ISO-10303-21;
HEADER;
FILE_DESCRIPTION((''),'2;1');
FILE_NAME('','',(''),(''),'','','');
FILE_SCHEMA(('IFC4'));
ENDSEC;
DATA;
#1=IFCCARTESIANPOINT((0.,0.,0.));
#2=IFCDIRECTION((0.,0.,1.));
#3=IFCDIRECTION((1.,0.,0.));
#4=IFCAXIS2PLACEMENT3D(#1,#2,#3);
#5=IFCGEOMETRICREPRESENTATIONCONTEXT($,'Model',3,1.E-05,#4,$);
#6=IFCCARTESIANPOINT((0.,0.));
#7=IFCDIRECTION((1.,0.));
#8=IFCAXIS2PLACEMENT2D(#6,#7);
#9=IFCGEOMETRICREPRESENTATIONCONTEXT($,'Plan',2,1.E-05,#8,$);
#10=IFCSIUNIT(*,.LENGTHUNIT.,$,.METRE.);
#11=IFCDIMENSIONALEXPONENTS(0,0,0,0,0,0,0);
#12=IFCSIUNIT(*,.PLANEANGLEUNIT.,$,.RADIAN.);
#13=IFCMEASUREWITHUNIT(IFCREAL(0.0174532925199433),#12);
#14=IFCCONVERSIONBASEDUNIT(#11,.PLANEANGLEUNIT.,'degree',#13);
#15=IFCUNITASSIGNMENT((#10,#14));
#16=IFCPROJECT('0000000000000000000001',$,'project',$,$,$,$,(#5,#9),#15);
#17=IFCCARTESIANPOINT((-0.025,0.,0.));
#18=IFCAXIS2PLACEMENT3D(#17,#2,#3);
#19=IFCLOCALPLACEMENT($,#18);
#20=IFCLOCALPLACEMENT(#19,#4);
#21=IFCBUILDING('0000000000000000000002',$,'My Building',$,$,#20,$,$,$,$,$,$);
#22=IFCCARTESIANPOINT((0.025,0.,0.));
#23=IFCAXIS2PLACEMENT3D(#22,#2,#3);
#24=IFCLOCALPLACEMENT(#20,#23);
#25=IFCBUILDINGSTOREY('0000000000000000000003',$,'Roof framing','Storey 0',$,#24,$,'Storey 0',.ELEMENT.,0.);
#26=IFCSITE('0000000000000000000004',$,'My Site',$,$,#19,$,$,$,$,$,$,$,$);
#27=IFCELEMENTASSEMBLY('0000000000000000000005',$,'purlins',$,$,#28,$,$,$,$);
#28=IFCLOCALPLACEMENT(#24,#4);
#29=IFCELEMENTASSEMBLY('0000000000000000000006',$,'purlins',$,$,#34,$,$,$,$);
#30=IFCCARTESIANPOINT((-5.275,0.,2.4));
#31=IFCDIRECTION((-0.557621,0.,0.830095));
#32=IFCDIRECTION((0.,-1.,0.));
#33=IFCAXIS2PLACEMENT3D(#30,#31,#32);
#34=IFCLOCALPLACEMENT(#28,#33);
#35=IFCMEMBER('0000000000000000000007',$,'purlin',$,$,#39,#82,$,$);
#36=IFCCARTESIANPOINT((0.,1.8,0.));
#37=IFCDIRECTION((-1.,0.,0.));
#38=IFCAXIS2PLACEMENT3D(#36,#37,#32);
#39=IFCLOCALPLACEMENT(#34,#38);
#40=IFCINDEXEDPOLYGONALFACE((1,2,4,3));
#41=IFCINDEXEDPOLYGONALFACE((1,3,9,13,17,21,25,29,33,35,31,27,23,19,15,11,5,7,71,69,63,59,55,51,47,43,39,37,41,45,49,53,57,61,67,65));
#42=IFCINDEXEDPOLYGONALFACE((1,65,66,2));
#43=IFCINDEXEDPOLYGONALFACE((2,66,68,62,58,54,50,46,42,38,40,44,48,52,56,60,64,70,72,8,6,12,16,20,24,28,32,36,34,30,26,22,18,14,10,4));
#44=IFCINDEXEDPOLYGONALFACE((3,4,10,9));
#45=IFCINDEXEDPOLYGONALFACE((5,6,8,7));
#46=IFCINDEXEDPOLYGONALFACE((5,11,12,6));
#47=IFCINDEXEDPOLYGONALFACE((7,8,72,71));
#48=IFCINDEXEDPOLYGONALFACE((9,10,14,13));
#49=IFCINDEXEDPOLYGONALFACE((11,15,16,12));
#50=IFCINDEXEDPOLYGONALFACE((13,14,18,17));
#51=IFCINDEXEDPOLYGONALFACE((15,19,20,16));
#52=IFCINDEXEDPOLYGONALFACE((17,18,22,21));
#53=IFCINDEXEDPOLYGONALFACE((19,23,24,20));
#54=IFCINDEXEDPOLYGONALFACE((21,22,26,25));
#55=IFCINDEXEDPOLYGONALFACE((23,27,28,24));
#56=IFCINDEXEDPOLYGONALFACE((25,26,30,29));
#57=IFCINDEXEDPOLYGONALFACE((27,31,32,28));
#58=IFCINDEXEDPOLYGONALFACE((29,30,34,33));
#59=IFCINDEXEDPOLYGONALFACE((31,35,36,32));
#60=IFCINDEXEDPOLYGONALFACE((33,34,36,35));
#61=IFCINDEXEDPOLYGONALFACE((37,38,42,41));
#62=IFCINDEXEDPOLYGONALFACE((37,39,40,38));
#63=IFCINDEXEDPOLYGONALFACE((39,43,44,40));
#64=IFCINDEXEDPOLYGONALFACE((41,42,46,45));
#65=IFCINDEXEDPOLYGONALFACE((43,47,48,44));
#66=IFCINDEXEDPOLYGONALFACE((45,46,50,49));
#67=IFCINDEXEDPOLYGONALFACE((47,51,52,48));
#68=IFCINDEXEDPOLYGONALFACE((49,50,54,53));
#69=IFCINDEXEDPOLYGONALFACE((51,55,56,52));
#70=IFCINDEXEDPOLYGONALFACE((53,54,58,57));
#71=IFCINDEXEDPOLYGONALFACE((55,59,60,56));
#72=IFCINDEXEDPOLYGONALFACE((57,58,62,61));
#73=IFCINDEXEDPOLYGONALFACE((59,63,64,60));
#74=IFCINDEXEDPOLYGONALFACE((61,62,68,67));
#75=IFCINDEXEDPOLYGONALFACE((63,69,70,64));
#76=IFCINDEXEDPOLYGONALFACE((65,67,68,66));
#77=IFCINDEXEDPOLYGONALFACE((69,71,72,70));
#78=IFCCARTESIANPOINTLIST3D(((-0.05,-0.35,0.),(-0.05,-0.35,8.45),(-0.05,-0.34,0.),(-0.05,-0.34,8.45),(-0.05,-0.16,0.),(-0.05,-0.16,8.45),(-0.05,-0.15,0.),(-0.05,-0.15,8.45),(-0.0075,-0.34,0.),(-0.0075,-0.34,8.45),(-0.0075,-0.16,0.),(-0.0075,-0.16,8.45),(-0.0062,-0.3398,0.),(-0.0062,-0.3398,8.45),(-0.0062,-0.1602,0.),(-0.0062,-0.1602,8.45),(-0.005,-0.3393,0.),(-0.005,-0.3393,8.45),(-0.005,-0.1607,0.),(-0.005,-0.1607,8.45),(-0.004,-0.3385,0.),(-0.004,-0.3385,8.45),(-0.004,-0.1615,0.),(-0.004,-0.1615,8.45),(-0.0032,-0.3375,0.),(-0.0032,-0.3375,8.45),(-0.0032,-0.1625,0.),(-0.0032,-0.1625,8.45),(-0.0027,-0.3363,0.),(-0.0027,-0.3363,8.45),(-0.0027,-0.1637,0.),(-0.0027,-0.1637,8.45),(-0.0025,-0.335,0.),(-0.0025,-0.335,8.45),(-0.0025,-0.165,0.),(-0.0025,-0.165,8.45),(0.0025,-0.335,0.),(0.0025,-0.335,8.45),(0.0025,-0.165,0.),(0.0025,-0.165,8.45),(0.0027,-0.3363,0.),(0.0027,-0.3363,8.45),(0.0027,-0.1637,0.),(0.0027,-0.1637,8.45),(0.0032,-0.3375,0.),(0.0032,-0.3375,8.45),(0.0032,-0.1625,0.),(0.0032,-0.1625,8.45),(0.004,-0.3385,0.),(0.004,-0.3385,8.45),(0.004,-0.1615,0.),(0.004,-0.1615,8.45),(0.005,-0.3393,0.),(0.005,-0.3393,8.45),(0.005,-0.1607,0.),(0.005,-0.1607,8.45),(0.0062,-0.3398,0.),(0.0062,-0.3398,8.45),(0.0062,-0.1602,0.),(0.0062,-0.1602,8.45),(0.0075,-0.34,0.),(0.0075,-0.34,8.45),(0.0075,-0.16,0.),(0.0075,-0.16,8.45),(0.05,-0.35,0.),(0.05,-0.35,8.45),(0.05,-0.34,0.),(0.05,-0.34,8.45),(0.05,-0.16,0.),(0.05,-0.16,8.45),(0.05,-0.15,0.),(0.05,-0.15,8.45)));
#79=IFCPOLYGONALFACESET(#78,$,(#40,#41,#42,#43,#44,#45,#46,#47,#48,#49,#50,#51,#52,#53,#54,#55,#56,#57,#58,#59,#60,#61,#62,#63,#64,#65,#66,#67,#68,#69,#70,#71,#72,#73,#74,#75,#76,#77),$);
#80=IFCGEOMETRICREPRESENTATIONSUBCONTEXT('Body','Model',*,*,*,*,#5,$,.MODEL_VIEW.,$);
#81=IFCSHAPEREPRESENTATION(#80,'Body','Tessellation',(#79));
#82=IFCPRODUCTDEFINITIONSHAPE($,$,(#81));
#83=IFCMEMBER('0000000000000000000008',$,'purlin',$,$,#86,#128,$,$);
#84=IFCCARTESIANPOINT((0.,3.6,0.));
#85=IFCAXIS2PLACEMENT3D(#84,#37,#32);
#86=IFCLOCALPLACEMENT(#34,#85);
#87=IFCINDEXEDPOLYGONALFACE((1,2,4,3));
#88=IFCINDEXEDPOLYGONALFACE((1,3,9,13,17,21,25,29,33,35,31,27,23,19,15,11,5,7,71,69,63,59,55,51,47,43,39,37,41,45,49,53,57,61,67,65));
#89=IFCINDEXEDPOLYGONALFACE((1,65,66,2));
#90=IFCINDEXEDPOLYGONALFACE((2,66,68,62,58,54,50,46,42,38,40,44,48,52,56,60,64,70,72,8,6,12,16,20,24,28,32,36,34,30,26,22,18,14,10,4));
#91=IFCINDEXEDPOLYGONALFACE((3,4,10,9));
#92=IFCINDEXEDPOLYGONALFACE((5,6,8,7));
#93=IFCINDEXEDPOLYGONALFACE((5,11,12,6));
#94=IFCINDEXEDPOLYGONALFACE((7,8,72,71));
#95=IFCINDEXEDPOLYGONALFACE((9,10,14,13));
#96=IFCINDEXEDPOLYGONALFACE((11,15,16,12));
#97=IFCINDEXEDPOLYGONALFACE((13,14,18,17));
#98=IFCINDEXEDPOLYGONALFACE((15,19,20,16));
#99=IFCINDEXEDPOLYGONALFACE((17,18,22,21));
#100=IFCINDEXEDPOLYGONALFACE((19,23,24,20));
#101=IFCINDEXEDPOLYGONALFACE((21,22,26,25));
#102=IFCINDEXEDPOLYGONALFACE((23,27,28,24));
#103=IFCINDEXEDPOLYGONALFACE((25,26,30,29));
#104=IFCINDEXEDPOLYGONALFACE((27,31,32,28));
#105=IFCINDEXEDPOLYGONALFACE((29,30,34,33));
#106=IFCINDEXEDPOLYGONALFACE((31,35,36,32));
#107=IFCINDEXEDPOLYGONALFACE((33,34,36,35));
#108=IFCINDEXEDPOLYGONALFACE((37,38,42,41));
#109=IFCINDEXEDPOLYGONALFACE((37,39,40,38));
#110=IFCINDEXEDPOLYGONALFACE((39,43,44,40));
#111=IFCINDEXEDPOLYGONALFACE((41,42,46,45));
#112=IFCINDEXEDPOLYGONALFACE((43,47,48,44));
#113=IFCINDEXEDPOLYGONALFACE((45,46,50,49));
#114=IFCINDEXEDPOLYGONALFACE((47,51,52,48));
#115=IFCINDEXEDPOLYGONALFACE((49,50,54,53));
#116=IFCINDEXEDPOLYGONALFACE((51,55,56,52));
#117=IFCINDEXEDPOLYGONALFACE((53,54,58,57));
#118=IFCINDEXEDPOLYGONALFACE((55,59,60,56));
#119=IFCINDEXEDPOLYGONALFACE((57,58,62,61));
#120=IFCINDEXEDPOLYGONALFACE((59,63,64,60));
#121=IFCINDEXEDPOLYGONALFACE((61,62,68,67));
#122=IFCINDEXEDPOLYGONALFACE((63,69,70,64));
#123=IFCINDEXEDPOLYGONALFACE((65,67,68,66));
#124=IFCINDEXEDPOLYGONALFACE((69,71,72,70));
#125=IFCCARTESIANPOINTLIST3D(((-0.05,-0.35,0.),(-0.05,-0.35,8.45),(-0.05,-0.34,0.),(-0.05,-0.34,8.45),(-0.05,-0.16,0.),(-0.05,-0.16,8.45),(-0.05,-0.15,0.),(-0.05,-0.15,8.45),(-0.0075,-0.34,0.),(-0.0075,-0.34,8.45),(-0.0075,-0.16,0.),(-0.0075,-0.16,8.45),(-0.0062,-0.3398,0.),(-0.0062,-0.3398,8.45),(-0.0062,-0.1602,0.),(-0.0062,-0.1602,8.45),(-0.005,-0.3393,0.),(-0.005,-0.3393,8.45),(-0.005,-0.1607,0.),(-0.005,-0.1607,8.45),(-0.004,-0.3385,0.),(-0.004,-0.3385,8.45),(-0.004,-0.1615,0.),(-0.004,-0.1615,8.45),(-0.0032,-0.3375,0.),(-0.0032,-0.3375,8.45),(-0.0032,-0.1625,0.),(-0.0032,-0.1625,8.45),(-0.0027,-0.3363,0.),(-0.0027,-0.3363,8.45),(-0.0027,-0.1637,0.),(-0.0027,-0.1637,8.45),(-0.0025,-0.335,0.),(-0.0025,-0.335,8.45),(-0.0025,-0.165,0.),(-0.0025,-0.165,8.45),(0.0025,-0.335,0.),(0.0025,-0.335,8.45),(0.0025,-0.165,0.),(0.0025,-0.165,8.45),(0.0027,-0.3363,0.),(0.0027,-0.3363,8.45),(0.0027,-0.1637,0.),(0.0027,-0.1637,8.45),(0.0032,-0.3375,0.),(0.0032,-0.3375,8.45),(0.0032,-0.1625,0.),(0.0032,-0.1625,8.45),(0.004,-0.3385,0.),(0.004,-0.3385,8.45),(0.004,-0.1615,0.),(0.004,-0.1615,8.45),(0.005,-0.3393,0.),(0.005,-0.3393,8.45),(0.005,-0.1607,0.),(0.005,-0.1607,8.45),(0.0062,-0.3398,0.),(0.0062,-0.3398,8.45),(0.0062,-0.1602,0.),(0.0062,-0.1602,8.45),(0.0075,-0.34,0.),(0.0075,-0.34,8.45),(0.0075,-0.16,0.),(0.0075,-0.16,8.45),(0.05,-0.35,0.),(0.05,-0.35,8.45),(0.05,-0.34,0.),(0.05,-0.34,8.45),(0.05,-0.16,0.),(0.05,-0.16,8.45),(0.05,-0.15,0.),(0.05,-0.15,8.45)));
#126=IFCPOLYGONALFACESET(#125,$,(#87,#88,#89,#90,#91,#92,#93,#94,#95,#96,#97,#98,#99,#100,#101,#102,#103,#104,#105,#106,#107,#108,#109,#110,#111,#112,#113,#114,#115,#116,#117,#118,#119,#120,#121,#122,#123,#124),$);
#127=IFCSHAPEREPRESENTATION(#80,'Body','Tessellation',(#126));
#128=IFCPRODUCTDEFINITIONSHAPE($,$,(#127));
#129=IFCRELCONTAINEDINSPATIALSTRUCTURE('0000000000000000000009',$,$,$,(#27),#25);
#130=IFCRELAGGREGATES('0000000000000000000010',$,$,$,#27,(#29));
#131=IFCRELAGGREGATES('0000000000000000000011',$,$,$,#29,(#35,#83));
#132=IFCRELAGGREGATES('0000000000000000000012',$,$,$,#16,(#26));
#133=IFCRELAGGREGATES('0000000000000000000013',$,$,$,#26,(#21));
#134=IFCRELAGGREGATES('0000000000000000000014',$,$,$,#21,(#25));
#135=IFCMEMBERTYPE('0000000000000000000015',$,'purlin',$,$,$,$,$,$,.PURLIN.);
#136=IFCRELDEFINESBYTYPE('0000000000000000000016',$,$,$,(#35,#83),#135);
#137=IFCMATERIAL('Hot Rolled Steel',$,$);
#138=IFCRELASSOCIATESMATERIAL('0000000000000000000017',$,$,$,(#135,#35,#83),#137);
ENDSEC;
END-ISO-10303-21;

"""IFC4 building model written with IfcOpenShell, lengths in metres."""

from ifc_helpers import new_model, entity, si_unit, converted_unit, frame, frame_2d, origin_with_axes, origin_2d_with_axis, place, context, subcontext, project, spatial, i_section, extrude, material, material_profile, profile_set, profile_usage, type_object, element, aggregate, save


model = new_model("IFC4")

# Units and contexts
model_context = context("Model", 3, precision=1e-05, world=origin_with_axes())
plan_context = context("Plan", 2, precision=1e-05, world=origin_2d_with_axis())
body_context = subcontext(model_context, "Body", "Model", "MODEL_VIEW")
ifc_project = project(units=[si_unit("LENGTHUNIT", "METRE"), converted_unit("PLANEANGLEUNIT", "degree", entity("IfcReal", 0.0174532925199433), si_unit("PLANEANGLEUNIT", "RADIAN"), dimensions=[0, 0, 0, 0, 0, 0, 0])], contexts=[model_context, plan_context])

# Site, building, storey
site_placement = place(None, frame((-0.025, 0.0, 0.0), z_axis=(0.0, 0.0, 1.0), x_axis=(1.0, 0.0, 0.0)))
site = spatial("IfcSite", under=ifc_project, at=site_placement, Name="My Site")
building_placement = place(site_placement, origin_with_axes())
building = spatial("IfcBuilding", under=site, at=building_placement, Name="My Building")
storey_placement = place(building_placement, frame((0.025, 0.0, 0.0), z_axis=(0.0, 0.0, 1.0), x_axis=(1.0, 0.0, 0.0)))
storey = spatial("IfcBuildingStorey", under=building, at=storey_placement, Name="Roof framing", Description="Storey 0", LongName="Storey 0", CompositionType="ELEMENT", Elevation=0.0)

# Element assemblies, members
assembly_1_placement = place(storey_placement, origin_with_axes())
assembly_1 = element("IfcElementAssembly", 1, at=assembly_1_placement, inside=storey, Name="purlins")
assembly_2_placement = place(assembly_1_placement, frame((-5.275, 0.0, 2.4), z_axis=(-0.557621, 0.0, 0.830095), x_axis=(0.0, -1.0, 0.0)))
assembly_2 = element("IfcElementAssembly", 2, at=assembly_2_placement, Name="purlins")
aggregate(assembly_1, [assembly_2])
ifc_material_1 = material(Name="Hot Rolled Steel")
ifc_material_profile_1 = material_profile(ifc_material_1, i_section(OverallWidth=0.1, OverallDepth=0.2, WebThickness=0.005, FlangeThickness=0.01, FilletRadius=0.005, at=frame_2d((0.0, -0.25), x_axis=(1.0, 0.0))))
ifc_profile_set_1 = profile_set([ifc_material_profile_1])
ifc_profile_usage_1 = profile_usage(ifc_profile_set_1)
member_type_1 = type_object("IfcMemberType", Name="purlin", PredefinedType="PURLIN", material=ifc_profile_set_1)
member_1_placement = place(assembly_2_placement, frame((0.0, 1.8, 0.0), z_axis=(-1.0, 0.0, 0.0), x_axis=(0.0, -1.0, 0.0)))
member_1 = element("IfcMember", 3, at=member_1_placement, type_object=member_type_1, material=ifc_profile_usage_1, Name="purlin", context=body_context, shape_type="SweptSolid", body=[
    extrude(i_section(OverallWidth=0.1, OverallDepth=0.2, WebThickness=0.005, FlangeThickness=0.01, FilletRadius=0.005, at=frame_2d((0.0, -0.25), x_axis=(1.0, 0.0))), origin_with_axes(), (0.0, 0.0, 1.0), 8.45),
])
ifc_profile_usage_2 = profile_usage(ifc_profile_set_1)
member_2_placement = place(assembly_2_placement, frame((0.0, 3.6, 0.0), z_axis=(-1.0, 0.0, 0.0), x_axis=(0.0, -1.0, 0.0)))
member_2 = element("IfcMember", 4, at=member_2_placement, type_object=member_type_1, material=ifc_profile_usage_2, Name="purlin", context=body_context, shape_type="SweptSolid", body=[
    extrude(i_section(OverallWidth=0.1, OverallDepth=0.2, WebThickness=0.005, FlangeThickness=0.01, FilletRadius=0.005, at=frame_2d((0.0, -0.25), x_axis=(1.0, 0.0))), origin_with_axes(), (0.0, 0.0, 1.0), 8.45),
])
aggregate(assembly_2, [member_1, member_2])

save(model, "model.ifc")
